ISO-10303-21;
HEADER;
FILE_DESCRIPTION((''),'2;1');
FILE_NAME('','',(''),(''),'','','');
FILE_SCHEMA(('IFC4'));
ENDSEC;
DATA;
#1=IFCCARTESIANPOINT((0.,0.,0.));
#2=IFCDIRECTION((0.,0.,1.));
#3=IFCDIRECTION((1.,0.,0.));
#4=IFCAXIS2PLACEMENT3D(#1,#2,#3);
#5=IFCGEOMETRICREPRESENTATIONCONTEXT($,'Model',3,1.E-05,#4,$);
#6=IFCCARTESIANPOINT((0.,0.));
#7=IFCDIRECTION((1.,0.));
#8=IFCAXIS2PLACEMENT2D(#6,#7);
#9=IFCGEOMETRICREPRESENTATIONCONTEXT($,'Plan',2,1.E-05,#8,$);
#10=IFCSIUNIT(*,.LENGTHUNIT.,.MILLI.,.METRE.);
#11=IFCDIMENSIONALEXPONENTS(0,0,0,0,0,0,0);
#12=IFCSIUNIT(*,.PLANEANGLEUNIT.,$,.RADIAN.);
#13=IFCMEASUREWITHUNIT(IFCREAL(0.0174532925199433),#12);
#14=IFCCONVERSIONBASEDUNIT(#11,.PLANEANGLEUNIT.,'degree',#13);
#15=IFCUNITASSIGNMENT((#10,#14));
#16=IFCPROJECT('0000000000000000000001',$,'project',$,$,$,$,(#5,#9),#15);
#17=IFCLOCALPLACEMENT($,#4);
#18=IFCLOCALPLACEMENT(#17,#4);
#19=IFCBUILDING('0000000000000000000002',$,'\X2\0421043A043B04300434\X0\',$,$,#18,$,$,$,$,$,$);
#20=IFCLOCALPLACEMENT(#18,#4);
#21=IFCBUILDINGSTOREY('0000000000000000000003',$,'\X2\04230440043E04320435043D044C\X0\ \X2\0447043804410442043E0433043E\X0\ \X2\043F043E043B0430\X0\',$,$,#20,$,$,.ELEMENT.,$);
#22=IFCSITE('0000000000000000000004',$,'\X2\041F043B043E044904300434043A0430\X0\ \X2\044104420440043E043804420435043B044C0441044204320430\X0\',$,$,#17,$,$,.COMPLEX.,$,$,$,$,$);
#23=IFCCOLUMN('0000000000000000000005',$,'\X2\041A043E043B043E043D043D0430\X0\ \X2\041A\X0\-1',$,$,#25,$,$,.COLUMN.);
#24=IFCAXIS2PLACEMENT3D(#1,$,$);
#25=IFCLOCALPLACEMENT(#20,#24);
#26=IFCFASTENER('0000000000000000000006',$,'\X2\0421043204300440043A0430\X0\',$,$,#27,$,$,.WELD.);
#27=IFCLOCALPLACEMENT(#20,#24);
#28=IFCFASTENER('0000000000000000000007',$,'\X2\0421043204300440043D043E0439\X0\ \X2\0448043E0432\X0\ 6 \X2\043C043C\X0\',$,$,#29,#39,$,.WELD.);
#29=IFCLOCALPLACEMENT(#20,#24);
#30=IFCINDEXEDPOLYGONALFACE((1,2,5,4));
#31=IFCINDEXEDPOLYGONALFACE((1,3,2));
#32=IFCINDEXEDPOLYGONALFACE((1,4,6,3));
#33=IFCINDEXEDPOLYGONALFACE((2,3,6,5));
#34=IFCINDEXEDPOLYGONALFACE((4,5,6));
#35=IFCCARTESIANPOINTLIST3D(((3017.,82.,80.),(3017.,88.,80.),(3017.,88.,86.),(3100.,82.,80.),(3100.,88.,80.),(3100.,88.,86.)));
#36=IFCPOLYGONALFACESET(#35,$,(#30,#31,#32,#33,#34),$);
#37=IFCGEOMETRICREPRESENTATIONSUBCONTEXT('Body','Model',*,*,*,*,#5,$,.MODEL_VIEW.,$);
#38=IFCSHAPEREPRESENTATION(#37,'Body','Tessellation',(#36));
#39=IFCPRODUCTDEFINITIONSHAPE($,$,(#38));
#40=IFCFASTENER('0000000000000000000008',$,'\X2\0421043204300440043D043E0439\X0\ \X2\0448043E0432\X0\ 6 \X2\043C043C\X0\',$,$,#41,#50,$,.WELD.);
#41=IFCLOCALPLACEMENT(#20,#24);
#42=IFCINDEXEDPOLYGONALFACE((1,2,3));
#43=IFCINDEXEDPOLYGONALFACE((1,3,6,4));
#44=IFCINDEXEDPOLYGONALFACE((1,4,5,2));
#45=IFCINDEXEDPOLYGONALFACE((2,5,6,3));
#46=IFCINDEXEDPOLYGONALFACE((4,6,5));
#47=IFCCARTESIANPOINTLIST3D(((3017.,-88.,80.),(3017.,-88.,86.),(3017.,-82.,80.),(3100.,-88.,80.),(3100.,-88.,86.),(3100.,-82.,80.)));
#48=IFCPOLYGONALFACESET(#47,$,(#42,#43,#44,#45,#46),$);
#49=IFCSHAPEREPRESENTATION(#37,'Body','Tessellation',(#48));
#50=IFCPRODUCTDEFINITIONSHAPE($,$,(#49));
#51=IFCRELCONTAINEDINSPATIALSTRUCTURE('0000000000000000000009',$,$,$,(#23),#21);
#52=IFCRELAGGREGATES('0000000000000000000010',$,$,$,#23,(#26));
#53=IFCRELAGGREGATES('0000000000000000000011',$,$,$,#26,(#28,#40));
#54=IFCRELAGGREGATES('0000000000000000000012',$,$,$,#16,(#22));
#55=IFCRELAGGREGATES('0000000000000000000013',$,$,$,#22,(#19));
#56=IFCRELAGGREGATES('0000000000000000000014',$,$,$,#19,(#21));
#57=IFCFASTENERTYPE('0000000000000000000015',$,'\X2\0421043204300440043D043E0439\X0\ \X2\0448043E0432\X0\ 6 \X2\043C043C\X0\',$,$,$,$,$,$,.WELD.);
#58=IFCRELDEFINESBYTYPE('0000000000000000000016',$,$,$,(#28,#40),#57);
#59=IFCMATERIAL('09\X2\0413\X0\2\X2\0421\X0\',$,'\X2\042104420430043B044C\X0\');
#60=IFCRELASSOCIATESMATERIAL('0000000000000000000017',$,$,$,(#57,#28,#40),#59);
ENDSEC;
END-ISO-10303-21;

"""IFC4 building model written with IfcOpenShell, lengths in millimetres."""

from ifc_helpers import new_model, entity, si_unit, converted_unit, frame, origin_with_axes, origin_2d_with_axis, place, context, subcontext, project, spatial, line, indexed_curve, outline, extrude, material, material_profile, profile_set, profile_usage, type_object, element, aggregate, save


model = new_model("IFC4")

# Units and contexts
model_context = context("Model", 3, precision=1e-05, world=origin_with_axes())
plan_context = context("Plan", 2, precision=1e-05, world=origin_2d_with_axis())
body_context = subcontext(model_context, "Body", "Model", "MODEL_VIEW")
ifc_project = project(units=[si_unit("LENGTHUNIT", "METRE", prefix="MILLI"), converted_unit("PLANEANGLEUNIT", "degree", entity("IfcReal", 0.0174532925199433), si_unit("PLANEANGLEUNIT", "RADIAN"), dimensions=[0, 0, 0, 0, 0, 0, 0])], contexts=[model_context, plan_context])

# Site, building, storey
site_placement = place(None, origin_with_axes())
site = spatial("IfcSite", under=ifc_project, at=site_placement, Name="Площадка строительства", CompositionType="COMPLEX")
building_placement = place(site_placement, origin_with_axes())
building = spatial("IfcBuilding", under=site, at=building_placement, Name="Склад")
storey_placement = place(building_placement, origin_with_axes())
storey = spatial("IfcBuildingStorey", under=building, at=storey_placement, Name="Уровень чистого пола", CompositionType="ELEMENT")

# Column
placement = place(storey_placement, origin_with_axes())
column_1 = element("IfcColumn", 1, at=placement, inside=storey, Name="Колонна К-1", PredefinedType="COLUMN")

# Shared definitions
ifc_material_1 = material(Name="09Г2С", Category="Сталь")

# Fasteners
fastener_1_placement = place(placement, frame((3000.0, 0.0, 0.0), z_axis=(0.0, 0.0, 1.0), x_axis=(1.0, 0.0, 0.0)))
fastener_1 = element("IfcFastener", 2, at=fastener_1_placement, Name="Сварка", PredefinedType="WELD")
aggregate(column_1, [fastener_1])
ifc_material_profile_1 = material_profile(ifc_material_1, outline(indexed_curve([(0.0, 0.0), (6.0, 0.0), (0.0, 6.0)], segments=[line(2, 3), line(3, 1), line(1, 2)], self_intersect=False)))
ifc_profile_set_1 = profile_set([ifc_material_profile_1])
ifc_profile_usage_1 = profile_usage(ifc_profile_set_1, cardinal=5)
fastener_type = type_object("IfcFastenerType", Name="Сварной шов 6 мм", PredefinedType="WELD", material=ifc_profile_set_1)
fastener_2_placement = place(fastener_1_placement, frame((100.0, 88.0, 80.0), z_axis=(-1.0, 0.0, 0.0), x_axis=(0.0, -1.0, 0.0)))
fastener_2 = element("IfcFastener", 3, at=fastener_2_placement, type_object=fastener_type, material=ifc_profile_usage_1, Name="Сварной шов 6 мм", PredefinedType="WELD", context=body_context, shape_type="SweptSolid", body=[
    extrude(outline(indexed_curve([(0.0, 0.0), (6.0, 0.0), (0.0, 6.0)], segments=[line(2, 3), line(3, 1), line(1, 2)], self_intersect=False)), origin_with_axes(), (0.0, 0.0, 1.0), 83.0),
])
fastener_3_placement = place(fastener_1_placement, frame((17.0, -88.0, 80.0), z_axis=(1.0, 0.0, 0.0), x_axis=(0.0, 1.0, 0.0)))
fastener_3 = element("IfcFastener", 4, at=fastener_3_placement, type_object=fastener_type, material=ifc_profile_usage_1, Name="Сварной шов 6 мм", PredefinedType="WELD", context=body_context, shape_type="SweptSolid", body=[
    extrude(outline(indexed_curve([(0.0, 0.0), (6.0, 0.0), (0.0, 6.0)], segments=[line(2, 3), line(3, 1), line(1, 2)], self_intersect=False)), origin_with_axes(), (0.0, 0.0, 1.0), 83.0),
])
aggregate(fastener_1, [fastener_2, fastener_3])

save(model, "model.ifc")
